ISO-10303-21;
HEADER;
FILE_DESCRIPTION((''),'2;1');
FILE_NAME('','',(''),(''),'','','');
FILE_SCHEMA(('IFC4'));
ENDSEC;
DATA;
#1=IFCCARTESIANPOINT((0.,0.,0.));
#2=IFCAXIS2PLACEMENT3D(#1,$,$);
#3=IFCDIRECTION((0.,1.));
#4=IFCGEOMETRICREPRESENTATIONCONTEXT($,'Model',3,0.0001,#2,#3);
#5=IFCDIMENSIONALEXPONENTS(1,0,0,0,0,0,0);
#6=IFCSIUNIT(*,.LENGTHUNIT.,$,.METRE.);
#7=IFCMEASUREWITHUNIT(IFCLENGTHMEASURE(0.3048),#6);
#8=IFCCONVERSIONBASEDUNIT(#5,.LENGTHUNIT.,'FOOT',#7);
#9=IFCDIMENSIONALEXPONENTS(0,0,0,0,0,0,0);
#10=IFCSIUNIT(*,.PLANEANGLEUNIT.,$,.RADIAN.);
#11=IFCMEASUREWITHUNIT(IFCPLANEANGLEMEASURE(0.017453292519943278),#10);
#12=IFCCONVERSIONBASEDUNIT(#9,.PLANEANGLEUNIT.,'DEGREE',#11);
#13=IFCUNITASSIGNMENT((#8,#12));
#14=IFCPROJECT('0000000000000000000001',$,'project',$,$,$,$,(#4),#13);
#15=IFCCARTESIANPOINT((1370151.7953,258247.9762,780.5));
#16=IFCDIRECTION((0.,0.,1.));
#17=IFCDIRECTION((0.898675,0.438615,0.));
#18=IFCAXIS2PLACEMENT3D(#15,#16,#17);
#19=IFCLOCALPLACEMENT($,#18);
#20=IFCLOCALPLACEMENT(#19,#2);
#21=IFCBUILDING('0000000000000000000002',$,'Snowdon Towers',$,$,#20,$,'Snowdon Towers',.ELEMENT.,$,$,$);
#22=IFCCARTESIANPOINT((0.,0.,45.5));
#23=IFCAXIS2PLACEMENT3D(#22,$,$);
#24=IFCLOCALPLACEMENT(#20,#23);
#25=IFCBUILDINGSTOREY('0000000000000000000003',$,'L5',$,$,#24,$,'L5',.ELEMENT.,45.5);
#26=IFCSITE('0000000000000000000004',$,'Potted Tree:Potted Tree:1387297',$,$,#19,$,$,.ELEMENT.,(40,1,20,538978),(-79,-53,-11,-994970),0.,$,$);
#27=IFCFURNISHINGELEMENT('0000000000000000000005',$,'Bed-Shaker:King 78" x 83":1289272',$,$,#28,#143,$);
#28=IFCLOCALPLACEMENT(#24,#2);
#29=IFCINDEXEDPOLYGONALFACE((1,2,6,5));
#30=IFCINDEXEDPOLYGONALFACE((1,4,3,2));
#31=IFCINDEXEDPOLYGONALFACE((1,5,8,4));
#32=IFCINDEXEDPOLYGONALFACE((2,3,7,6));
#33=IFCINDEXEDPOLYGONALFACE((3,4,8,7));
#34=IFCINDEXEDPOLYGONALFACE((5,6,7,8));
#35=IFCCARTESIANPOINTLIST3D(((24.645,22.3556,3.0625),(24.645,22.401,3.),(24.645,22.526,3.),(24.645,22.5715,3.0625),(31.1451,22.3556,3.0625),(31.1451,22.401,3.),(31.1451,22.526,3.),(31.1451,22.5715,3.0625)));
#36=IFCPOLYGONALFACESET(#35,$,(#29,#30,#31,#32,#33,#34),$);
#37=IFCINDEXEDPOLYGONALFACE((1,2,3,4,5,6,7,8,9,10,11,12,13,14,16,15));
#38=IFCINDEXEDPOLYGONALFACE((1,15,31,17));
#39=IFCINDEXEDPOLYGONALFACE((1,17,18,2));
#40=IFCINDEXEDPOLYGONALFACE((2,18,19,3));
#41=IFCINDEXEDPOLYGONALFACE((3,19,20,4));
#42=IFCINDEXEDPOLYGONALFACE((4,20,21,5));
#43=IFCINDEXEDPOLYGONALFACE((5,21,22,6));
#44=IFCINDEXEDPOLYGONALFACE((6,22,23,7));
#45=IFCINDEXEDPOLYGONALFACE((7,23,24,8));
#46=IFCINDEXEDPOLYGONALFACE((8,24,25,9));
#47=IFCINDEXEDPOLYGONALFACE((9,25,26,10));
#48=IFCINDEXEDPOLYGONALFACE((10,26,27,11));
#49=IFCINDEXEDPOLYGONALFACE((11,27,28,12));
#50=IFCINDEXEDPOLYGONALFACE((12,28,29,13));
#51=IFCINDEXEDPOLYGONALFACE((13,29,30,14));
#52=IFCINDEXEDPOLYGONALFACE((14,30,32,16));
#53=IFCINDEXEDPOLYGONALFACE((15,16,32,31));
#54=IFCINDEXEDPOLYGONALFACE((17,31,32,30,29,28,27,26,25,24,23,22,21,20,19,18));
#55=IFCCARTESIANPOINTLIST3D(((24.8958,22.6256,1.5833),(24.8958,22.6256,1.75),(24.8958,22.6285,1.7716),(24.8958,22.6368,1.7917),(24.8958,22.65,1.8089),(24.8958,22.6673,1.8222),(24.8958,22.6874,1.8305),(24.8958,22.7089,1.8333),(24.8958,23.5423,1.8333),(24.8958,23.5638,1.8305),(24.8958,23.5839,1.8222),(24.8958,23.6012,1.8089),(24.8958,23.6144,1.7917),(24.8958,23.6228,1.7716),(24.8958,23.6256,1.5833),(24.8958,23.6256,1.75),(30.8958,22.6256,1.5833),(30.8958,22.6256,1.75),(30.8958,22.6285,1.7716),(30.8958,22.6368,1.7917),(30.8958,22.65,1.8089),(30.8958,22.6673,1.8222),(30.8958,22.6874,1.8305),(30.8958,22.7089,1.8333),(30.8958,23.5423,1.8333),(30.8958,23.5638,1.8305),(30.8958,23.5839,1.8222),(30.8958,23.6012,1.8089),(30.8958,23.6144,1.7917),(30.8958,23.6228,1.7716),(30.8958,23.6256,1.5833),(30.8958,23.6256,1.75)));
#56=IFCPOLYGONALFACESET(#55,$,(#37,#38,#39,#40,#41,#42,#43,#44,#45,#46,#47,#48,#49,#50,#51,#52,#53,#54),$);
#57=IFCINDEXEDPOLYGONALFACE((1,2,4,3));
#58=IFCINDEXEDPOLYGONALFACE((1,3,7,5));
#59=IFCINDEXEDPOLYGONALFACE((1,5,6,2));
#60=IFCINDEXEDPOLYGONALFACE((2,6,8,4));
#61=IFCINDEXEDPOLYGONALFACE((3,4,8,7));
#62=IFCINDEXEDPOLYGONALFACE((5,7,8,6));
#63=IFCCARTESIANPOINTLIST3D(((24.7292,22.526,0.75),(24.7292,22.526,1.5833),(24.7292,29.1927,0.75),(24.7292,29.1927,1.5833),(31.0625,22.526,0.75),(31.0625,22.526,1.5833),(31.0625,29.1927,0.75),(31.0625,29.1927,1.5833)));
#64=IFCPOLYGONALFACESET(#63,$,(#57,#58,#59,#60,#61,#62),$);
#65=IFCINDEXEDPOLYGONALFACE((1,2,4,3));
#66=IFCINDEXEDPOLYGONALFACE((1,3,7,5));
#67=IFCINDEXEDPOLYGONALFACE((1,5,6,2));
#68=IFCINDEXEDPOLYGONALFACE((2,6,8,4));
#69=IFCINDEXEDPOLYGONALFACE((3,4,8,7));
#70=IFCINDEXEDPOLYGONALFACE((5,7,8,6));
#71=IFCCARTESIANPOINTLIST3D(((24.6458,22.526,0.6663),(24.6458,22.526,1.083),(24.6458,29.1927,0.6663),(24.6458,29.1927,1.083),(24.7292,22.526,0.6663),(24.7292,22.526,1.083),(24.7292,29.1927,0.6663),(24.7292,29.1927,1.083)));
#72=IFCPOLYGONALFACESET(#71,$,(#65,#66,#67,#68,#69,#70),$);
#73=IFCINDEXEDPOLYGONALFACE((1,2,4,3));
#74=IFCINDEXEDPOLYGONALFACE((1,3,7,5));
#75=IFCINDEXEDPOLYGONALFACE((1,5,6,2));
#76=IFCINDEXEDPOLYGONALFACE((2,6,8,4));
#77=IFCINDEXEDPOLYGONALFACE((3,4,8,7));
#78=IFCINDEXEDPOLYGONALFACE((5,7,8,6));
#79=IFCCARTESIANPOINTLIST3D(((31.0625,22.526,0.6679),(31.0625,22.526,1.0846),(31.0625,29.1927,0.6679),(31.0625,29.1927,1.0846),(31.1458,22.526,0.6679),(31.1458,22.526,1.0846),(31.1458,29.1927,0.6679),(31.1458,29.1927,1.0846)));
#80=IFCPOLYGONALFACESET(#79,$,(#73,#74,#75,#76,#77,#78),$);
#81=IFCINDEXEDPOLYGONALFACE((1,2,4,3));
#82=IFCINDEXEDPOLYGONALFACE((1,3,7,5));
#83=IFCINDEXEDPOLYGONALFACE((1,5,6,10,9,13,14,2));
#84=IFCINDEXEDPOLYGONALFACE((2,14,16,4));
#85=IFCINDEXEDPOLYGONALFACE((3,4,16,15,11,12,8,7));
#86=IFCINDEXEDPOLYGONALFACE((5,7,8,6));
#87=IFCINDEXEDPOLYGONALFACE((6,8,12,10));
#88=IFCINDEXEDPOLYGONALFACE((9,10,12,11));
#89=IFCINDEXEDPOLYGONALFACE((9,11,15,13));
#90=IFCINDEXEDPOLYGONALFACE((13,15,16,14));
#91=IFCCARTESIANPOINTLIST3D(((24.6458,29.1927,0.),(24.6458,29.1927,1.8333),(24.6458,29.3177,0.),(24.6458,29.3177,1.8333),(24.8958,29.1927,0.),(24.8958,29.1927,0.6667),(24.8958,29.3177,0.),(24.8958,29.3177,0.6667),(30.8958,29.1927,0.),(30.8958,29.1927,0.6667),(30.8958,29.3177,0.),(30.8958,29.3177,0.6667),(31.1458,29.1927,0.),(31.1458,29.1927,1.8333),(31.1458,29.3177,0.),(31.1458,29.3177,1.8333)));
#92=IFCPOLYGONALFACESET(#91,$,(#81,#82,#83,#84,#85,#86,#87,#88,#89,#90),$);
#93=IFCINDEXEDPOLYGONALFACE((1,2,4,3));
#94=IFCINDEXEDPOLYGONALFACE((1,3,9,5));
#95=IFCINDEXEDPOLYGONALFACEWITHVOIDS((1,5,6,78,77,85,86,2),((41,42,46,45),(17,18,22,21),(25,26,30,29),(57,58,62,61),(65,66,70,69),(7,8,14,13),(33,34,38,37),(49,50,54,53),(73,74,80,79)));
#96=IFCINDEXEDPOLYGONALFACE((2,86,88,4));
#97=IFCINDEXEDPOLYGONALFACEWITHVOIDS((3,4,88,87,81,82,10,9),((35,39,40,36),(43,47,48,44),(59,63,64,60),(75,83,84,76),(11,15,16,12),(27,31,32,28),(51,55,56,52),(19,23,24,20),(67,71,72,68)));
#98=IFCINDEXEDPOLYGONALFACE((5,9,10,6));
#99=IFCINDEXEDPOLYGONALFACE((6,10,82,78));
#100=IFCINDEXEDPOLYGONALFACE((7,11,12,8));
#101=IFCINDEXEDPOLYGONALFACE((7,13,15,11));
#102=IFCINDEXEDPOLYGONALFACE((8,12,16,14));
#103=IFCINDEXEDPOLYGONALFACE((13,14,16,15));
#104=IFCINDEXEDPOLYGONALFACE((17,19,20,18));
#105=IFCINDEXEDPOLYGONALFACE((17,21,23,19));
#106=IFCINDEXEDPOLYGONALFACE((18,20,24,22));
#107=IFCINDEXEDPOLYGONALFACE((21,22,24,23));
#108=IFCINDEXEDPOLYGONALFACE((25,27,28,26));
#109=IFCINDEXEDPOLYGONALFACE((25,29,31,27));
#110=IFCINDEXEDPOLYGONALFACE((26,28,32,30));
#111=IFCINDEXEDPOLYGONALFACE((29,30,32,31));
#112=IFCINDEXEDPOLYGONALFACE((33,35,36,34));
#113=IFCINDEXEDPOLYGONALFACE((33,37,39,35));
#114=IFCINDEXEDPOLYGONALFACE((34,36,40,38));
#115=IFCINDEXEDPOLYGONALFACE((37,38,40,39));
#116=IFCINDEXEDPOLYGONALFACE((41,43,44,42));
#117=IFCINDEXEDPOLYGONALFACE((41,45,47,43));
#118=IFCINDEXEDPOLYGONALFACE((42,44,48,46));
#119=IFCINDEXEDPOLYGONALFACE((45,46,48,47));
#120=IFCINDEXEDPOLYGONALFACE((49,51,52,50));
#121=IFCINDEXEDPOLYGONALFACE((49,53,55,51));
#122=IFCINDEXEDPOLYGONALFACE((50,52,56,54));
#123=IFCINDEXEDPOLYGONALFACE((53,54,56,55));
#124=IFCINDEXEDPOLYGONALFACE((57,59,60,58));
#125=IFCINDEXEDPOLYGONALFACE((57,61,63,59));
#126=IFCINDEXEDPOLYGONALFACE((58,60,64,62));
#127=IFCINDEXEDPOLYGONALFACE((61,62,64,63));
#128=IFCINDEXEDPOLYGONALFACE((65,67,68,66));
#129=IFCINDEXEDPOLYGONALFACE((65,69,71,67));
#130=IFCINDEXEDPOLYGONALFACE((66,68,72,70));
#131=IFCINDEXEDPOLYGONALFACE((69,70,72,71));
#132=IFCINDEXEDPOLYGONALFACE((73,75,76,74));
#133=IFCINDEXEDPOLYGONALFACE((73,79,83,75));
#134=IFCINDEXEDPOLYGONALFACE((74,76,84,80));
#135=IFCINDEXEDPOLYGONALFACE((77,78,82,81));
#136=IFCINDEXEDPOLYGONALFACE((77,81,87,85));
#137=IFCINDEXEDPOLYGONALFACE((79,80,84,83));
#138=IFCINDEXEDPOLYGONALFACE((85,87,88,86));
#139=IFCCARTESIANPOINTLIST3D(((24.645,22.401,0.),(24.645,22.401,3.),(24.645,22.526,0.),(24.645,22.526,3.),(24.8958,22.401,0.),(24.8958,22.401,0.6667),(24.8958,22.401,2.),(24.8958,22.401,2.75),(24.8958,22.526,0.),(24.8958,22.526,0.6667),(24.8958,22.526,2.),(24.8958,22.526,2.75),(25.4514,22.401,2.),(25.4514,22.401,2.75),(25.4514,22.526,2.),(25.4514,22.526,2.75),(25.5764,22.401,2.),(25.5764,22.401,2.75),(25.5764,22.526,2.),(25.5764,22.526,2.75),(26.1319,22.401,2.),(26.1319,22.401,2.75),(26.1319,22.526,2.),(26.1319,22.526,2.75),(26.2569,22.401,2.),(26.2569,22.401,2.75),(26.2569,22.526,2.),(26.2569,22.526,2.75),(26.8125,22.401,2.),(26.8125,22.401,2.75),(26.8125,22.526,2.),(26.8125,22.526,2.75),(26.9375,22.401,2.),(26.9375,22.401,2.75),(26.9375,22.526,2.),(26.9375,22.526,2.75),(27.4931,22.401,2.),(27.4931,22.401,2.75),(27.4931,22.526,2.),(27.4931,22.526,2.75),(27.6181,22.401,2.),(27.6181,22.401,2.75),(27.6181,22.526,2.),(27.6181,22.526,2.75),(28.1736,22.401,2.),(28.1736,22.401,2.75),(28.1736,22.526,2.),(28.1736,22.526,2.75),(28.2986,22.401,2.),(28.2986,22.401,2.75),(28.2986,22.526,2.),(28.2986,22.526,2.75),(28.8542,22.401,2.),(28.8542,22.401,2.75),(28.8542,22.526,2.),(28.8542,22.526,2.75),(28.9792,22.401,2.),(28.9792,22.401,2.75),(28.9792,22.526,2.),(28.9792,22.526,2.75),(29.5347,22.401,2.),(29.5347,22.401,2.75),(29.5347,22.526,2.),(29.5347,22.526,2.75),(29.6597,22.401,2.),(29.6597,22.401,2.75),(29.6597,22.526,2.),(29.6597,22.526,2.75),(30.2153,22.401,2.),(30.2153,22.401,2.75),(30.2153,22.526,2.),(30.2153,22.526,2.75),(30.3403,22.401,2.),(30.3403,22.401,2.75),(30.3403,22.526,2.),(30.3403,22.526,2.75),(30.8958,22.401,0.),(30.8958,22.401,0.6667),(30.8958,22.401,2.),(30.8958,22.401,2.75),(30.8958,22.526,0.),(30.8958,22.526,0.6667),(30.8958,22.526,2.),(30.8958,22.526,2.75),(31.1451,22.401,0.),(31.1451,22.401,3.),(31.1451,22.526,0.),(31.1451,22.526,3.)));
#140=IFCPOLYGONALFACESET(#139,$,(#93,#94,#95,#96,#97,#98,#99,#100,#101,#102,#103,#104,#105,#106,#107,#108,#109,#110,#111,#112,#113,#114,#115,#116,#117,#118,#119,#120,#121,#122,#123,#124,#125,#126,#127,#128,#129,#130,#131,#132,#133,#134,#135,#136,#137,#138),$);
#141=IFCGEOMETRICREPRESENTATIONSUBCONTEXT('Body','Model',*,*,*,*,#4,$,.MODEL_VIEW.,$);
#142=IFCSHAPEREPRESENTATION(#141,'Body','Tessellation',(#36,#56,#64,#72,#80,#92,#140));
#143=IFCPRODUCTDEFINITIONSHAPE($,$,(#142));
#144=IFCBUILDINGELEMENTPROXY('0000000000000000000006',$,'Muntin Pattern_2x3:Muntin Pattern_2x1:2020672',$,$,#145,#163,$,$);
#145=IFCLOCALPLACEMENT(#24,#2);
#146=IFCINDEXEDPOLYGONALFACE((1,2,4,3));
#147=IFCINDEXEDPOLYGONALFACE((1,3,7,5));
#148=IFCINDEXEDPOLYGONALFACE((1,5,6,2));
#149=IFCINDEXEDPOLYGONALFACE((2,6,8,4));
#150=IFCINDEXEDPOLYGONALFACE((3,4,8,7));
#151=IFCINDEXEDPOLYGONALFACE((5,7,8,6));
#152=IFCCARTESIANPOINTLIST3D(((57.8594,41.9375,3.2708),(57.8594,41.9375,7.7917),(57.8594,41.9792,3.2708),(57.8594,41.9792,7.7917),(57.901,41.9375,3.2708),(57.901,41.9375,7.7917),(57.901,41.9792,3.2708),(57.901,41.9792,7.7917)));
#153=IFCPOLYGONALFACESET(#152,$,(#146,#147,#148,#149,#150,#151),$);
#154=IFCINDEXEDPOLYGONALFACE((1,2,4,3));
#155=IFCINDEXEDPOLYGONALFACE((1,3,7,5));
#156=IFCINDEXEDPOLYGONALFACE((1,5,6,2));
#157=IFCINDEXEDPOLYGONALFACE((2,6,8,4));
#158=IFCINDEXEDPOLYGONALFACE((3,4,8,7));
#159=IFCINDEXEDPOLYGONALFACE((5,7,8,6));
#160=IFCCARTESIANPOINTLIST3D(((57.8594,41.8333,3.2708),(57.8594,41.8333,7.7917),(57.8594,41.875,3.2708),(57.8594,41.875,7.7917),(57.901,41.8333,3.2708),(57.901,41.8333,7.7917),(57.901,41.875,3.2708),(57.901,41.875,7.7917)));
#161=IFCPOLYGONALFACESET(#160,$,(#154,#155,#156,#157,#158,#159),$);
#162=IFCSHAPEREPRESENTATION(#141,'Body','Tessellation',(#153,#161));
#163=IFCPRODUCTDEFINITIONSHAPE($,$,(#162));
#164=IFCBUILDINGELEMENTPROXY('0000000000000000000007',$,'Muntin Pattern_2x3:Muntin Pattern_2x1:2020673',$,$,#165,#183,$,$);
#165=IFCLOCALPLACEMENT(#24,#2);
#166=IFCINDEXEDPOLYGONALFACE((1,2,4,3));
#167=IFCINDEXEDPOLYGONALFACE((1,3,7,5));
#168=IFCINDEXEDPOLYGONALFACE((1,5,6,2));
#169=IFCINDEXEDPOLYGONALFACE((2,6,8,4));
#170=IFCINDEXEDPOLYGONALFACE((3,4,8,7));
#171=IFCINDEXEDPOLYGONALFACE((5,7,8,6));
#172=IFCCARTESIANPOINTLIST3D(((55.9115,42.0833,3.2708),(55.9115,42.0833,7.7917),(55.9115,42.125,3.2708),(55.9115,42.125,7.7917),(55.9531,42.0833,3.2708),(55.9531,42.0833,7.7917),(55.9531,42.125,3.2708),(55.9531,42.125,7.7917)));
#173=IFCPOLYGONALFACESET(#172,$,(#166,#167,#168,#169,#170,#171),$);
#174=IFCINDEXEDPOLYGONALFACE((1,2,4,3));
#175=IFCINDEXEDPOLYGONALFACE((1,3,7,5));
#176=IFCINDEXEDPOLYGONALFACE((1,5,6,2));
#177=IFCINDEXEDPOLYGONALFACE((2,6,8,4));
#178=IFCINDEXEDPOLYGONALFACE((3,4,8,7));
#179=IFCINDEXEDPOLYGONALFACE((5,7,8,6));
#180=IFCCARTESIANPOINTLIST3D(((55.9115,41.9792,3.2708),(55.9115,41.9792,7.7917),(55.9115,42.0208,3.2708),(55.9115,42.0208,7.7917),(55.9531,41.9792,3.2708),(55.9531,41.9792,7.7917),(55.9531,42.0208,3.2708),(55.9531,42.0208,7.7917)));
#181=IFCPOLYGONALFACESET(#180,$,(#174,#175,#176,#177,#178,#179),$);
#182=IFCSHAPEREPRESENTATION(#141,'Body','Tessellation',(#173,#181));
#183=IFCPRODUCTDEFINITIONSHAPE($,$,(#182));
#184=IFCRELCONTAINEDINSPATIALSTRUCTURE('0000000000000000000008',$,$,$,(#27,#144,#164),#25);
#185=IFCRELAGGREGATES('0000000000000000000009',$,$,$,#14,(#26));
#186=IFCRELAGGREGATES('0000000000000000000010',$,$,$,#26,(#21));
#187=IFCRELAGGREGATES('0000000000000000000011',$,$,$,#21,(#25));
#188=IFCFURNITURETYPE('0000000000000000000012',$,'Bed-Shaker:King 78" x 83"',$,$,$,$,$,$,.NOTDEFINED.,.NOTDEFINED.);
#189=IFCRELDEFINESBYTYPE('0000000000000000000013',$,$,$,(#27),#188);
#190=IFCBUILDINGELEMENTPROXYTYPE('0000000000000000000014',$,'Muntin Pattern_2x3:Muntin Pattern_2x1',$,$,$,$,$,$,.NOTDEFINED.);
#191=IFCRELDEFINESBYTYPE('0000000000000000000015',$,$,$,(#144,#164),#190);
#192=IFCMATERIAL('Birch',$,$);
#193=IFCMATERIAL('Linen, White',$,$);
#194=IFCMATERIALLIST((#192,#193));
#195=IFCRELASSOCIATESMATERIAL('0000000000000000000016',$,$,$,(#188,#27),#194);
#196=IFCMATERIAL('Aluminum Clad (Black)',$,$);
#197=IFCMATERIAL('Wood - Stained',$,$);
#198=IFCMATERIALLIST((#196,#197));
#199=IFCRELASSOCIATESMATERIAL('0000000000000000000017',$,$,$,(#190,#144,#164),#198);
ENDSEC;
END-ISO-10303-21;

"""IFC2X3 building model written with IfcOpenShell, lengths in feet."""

from ifc_helpers import new_model, entity, si_unit, converted_unit, direction, frame, frame_2d, origin, origin_2d_with_axis, place, context, subcontext, project, spatial, polyline, circle_curve, parameter, trimmed, segment, composite_curve, rectangle, outline, extrude, source, transform, mapped, material, material_list, type_object, type_shapes, element, save


model = new_model("IFC2X3")

# Units and contexts
model_context = context("Model", 3, precision=0.0001, world=origin(), true_north=direction((0.0, 1.0)))
body_context = subcontext(model_context, "Body", "Model", "MODEL_VIEW")
ifc_project = project(units=[converted_unit("LENGTHUNIT", "FOOT", entity("IfcLengthMeasure", 0.3048), si_unit("LENGTHUNIT", "METRE"), dimensions=[1, 0, 0, 0, 0, 0, 0]), converted_unit("PLANEANGLEUNIT", "DEGREE", entity("IfcPlaneAngleMeasure", 0.017453292519943278), si_unit("PLANEANGLEUNIT", "RADIAN"), dimensions=[0, 0, 0, 0, 0, 0, 0])], contexts=[model_context])

# Site, building, storey
site_placement = place(None, frame((1370151.7953, 258247.9762, 780.5), z_axis=(0.0, 0.0, 1.0), x_axis=(0.898675, 0.438615, 0.0)))
site = spatial("IfcSite", under=ifc_project, at=site_placement, Name="Potted Tree:Potted Tree:1387297", CompositionType="ELEMENT", RefLatitude=(40, 1, 20, 538978), RefLongitude=(-79, -53, -11, -994970), RefElevation=0.0)
building_placement = place(site_placement, origin())
building = spatial("IfcBuilding", under=site, at=building_placement, Name="Snowdon Towers", LongName="Snowdon Towers", CompositionType="ELEMENT")
storey_placement = place(building_placement, frame((0.0, 0.0, 45.5)))
storey = spatial("IfcBuildingStorey", under=building, at=storey_placement, Name="L5", LongName="L5", CompositionType="ELEMENT", Elevation=45.5)

# Shared definitions
ifc_material_1 = material(Name="Birch")

# Furnishing element
ifc_material_2 = material(Name="Linen, White")
ifc_material_list_1 = material_list([ifc_material_1, ifc_material_2])
furniture_type_1 = type_object("IfcFurnitureType", Name="Bed-Shaker:King 78\" x 83\"", AssemblyPlace="NOTDEFINED", material=ifc_material_list_1)
shared_shape_1 = source(origin(), body_context, "Body", "SweptSolid", [
    extrude(outline(polyline([(-0.0625, -0.0312), (0.0625, -0.0312), (0.108, 0.0312), (-0.108, 0.0312), (-0.0625, -0.0312)])), frame((-3.3118, -0.0625, 3.0312), z_axis=(1.0, 0.0, 0.0), x_axis=(0.0, 1.0, 0.0)), (0.0, 0.0, 1.0), 6.5002),
    extrude(outline(composite_curve([segment(polyline([(-0.5, -0.1389), (0.5, -0.1389)]), True, "CONTINUOUS"), segment(polyline([(0.5, -0.1389), (0.5, 0.0278)]), True, "CONTINUOUS"), segment(trimmed(circle_curve(frame_2d((0.4167, 0.0278), x_axis=(-1.0, 0.0)), 0.0833), [parameter(180.0)], [parameter(270.0)], True, "PARAMETER"), True, "CONTINUOUS"), segment(polyline([(0.4167, 0.1111), (-0.4167, 0.1111)]), True, "CONTINUOUS"), segment(trimmed(circle_curve(frame_2d((-0.4167, 0.0278), x_axis=(-1.0, 0.0)), 0.0833), [parameter(270.0)], [parameter(0.0)], True, "PARAMETER"), True, "CONTINUOUS"), segment(polyline([(-0.5, 0.0278), (-0.5, -0.1389)]), True, "CONTINUOUS")], self_intersect=False)), frame((-3.0625, -0.7246, 1.7222), z_axis=(1.0, 0.0, 0.0), x_axis=(0.0, 1.0, 0.0)), (0.0, 0.0, 1.0), 6.0),
    extrude(rectangle(XDim=6.3333, YDim=6.6667, at=origin_2d_with_axis()), frame((-0.0625, -3.4583, 0.75), z_axis=(0.0, 0.0, 1.0), x_axis=(-1.0, 0.0, 0.0)), (0.0, 0.0, 1.0), 0.8333),
    extrude(rectangle(XDim=0.0833, YDim=6.6667, at=frame_2d((0.0, 0.0), x_axis=(1.0, 0.0))), frame((3.1458, -3.4583, 0.6663)), (0.0, 0.0, 1.0), 0.4167),
    extrude(rectangle(XDim=0.0833, YDim=6.6667, at=frame_2d((0.0, 0.0), x_axis=(1.0, 0.0))), frame((-3.2708, -3.4583, 0.6679)), (0.0, 0.0, 1.0), 0.4167),
    extrude(outline(polyline([(3.0, -0.625), (3.25, -0.625), (3.25, 1.2083), (-3.25, 1.2083), (-3.25, -0.625), (-3.0, -0.625), (-3.0, 0.0417), (3.0, 0.0417), (3.0, -0.625)])), frame((-0.0625, -6.9167, 0.625), z_axis=(0.0, 1.0, 0.0), x_axis=(-1.0, 0.0, 0.0)), (0.0, 0.0, 1.0), 0.125),
    extrude(outline(polyline([(-2.0833, -3.2505), (0.9167, -3.2505), (0.9167, -2.9996), (0.25, -2.9996), (0.25, 3.0004), (0.9167, 3.0004), (0.9167, 3.2497), (-2.0833, 3.2497), (-2.0833, -3.2505)]), holes=[polyline([(-1.8333, 2.4448), (-1.8333, 3.0004), (-1.0833, 3.0004), (-1.0833, 2.4448), (-1.8333, 2.4448)]), polyline([(-1.8333, 1.7643), (-1.8333, 2.3198), (-1.0833, 2.3198), (-1.0833, 1.7643), (-1.8333, 1.7643)]), polyline([(-1.8333, 1.0837), (-1.8333, 1.6393), (-1.0833, 1.6393), (-1.0833, 1.0837), (-1.8333, 1.0837)]), polyline([(-1.8333, 0.4032), (-1.8333, 0.9587), (-1.0833, 0.9587), (-1.0833, 0.4032), (-1.8333, 0.4032)]), polyline([(-1.8333, -0.9579), (-1.8333, -0.4024), (-1.0833, -0.4024), (-1.0833, -0.9579), (-1.8333, -0.9579)]), polyline([(-1.8333, -1.6385), (-1.8333, -1.0829), (-1.0833, -1.0829), (-1.0833, -1.6385), (-1.8333, -1.6385)]), polyline([(-1.8333, -2.3191), (-1.8333, -1.7635), (-1.0833, -1.7635), (-1.0833, -2.3191), (-1.8333, -2.3191)]), polyline([(-1.8333, -2.9996), (-1.8333, -2.4441), (-1.0833, -2.4441), (-1.0833, -2.9996), (-1.8333, -2.9996)]), polyline([(-1.8333, -0.2774), (-1.8333, 0.2782), (-1.0833, 0.2782), (-1.0833, -0.2774), (-1.8333, -0.2774)])]), frame((-0.0621, -0.125, 0.9167), z_axis=(0.0, 1.0, 0.0), x_axis=(0.0, 0.0, -1.0)), (0.0, 0.0, 1.0), 0.125),
])
type_shapes(furniture_type_1, [shared_shape_1])
furnishing_1_placement = place(storey_placement, frame((27.8333, 22.401, 0.0), z_axis=(0.0, 0.0, 1.0), x_axis=(-1.0, 0.0, 0.0)))
element("IfcFurnishingElement", 1, at=furnishing_1_placement, inside=storey, type_object=furniture_type_1, material=ifc_material_list_1, Name="Bed-Shaker:King 78\" x 83\":1289272", context=body_context, shape_type="MappedRepresentation", body=[
    mapped(shared_shape_1, transform((0.0, 0.0, 0.0), scale=1.0)),
])

# Building element proxies
ifc_material_3 = material(Name="Aluminum Clad (Black)")
ifc_material_4 = material(Name="Wood - Stained")
ifc_material_list_2 = material_list([ifc_material_3, ifc_material_4])
building_element_proxy_type_1 = type_object("IfcBuildingElementProxyType", Name="Muntin Pattern_2x3:Muntin Pattern_2x1", PredefinedType="NOTDEFINED", material=ifc_material_list_2)
shared_shape_2 = source(origin(), body_context, "Body", "SweptSolid", [
    extrude(rectangle(XDim=0.0417, YDim=0.0417, at=frame_2d((0.0, 0.0), x_axis=(1.0, 0.0))), frame((0.0, 0.0521, 0.0), z_axis=(0.0, 0.0, 1.0), x_axis=(0.0, -1.0, 0.0)), (0.0, 0.0, 1.0), 4.5208),
    extrude(rectangle(XDim=0.0417, YDim=0.0417, at=frame_2d((0.0, 0.0), x_axis=(1.0, 0.0))), frame((0.0, -0.0521, 0.0), z_axis=(0.0, 0.0, 1.0), x_axis=(0.0, -1.0, 0.0)), (0.0, 0.0, 1.0), 4.5208),
])
type_shapes(building_element_proxy_type_1, [shared_shape_2])
for number, where, name in (
    (2, (57.8802, 41.9063, 3.2708), "Muntin Pattern_2x3:Muntin Pattern_2x1:2020672"),
    (3, (55.9323, 42.0521, 3.2708), "Muntin Pattern_2x3:Muntin Pattern_2x1:2020673"),
):
    element("IfcBuildingElementProxy", number, at=place(storey_placement, frame(where)), inside=storey, type_object=building_element_proxy_type_1, material=ifc_material_list_2, Name=name, context=body_context, shape_type="MappedRepresentation", body=[
        mapped(shared_shape_2, transform((0.0, 0.0, 0.0), scale=1.0)),
    ])

save(model, "model.ifc")
